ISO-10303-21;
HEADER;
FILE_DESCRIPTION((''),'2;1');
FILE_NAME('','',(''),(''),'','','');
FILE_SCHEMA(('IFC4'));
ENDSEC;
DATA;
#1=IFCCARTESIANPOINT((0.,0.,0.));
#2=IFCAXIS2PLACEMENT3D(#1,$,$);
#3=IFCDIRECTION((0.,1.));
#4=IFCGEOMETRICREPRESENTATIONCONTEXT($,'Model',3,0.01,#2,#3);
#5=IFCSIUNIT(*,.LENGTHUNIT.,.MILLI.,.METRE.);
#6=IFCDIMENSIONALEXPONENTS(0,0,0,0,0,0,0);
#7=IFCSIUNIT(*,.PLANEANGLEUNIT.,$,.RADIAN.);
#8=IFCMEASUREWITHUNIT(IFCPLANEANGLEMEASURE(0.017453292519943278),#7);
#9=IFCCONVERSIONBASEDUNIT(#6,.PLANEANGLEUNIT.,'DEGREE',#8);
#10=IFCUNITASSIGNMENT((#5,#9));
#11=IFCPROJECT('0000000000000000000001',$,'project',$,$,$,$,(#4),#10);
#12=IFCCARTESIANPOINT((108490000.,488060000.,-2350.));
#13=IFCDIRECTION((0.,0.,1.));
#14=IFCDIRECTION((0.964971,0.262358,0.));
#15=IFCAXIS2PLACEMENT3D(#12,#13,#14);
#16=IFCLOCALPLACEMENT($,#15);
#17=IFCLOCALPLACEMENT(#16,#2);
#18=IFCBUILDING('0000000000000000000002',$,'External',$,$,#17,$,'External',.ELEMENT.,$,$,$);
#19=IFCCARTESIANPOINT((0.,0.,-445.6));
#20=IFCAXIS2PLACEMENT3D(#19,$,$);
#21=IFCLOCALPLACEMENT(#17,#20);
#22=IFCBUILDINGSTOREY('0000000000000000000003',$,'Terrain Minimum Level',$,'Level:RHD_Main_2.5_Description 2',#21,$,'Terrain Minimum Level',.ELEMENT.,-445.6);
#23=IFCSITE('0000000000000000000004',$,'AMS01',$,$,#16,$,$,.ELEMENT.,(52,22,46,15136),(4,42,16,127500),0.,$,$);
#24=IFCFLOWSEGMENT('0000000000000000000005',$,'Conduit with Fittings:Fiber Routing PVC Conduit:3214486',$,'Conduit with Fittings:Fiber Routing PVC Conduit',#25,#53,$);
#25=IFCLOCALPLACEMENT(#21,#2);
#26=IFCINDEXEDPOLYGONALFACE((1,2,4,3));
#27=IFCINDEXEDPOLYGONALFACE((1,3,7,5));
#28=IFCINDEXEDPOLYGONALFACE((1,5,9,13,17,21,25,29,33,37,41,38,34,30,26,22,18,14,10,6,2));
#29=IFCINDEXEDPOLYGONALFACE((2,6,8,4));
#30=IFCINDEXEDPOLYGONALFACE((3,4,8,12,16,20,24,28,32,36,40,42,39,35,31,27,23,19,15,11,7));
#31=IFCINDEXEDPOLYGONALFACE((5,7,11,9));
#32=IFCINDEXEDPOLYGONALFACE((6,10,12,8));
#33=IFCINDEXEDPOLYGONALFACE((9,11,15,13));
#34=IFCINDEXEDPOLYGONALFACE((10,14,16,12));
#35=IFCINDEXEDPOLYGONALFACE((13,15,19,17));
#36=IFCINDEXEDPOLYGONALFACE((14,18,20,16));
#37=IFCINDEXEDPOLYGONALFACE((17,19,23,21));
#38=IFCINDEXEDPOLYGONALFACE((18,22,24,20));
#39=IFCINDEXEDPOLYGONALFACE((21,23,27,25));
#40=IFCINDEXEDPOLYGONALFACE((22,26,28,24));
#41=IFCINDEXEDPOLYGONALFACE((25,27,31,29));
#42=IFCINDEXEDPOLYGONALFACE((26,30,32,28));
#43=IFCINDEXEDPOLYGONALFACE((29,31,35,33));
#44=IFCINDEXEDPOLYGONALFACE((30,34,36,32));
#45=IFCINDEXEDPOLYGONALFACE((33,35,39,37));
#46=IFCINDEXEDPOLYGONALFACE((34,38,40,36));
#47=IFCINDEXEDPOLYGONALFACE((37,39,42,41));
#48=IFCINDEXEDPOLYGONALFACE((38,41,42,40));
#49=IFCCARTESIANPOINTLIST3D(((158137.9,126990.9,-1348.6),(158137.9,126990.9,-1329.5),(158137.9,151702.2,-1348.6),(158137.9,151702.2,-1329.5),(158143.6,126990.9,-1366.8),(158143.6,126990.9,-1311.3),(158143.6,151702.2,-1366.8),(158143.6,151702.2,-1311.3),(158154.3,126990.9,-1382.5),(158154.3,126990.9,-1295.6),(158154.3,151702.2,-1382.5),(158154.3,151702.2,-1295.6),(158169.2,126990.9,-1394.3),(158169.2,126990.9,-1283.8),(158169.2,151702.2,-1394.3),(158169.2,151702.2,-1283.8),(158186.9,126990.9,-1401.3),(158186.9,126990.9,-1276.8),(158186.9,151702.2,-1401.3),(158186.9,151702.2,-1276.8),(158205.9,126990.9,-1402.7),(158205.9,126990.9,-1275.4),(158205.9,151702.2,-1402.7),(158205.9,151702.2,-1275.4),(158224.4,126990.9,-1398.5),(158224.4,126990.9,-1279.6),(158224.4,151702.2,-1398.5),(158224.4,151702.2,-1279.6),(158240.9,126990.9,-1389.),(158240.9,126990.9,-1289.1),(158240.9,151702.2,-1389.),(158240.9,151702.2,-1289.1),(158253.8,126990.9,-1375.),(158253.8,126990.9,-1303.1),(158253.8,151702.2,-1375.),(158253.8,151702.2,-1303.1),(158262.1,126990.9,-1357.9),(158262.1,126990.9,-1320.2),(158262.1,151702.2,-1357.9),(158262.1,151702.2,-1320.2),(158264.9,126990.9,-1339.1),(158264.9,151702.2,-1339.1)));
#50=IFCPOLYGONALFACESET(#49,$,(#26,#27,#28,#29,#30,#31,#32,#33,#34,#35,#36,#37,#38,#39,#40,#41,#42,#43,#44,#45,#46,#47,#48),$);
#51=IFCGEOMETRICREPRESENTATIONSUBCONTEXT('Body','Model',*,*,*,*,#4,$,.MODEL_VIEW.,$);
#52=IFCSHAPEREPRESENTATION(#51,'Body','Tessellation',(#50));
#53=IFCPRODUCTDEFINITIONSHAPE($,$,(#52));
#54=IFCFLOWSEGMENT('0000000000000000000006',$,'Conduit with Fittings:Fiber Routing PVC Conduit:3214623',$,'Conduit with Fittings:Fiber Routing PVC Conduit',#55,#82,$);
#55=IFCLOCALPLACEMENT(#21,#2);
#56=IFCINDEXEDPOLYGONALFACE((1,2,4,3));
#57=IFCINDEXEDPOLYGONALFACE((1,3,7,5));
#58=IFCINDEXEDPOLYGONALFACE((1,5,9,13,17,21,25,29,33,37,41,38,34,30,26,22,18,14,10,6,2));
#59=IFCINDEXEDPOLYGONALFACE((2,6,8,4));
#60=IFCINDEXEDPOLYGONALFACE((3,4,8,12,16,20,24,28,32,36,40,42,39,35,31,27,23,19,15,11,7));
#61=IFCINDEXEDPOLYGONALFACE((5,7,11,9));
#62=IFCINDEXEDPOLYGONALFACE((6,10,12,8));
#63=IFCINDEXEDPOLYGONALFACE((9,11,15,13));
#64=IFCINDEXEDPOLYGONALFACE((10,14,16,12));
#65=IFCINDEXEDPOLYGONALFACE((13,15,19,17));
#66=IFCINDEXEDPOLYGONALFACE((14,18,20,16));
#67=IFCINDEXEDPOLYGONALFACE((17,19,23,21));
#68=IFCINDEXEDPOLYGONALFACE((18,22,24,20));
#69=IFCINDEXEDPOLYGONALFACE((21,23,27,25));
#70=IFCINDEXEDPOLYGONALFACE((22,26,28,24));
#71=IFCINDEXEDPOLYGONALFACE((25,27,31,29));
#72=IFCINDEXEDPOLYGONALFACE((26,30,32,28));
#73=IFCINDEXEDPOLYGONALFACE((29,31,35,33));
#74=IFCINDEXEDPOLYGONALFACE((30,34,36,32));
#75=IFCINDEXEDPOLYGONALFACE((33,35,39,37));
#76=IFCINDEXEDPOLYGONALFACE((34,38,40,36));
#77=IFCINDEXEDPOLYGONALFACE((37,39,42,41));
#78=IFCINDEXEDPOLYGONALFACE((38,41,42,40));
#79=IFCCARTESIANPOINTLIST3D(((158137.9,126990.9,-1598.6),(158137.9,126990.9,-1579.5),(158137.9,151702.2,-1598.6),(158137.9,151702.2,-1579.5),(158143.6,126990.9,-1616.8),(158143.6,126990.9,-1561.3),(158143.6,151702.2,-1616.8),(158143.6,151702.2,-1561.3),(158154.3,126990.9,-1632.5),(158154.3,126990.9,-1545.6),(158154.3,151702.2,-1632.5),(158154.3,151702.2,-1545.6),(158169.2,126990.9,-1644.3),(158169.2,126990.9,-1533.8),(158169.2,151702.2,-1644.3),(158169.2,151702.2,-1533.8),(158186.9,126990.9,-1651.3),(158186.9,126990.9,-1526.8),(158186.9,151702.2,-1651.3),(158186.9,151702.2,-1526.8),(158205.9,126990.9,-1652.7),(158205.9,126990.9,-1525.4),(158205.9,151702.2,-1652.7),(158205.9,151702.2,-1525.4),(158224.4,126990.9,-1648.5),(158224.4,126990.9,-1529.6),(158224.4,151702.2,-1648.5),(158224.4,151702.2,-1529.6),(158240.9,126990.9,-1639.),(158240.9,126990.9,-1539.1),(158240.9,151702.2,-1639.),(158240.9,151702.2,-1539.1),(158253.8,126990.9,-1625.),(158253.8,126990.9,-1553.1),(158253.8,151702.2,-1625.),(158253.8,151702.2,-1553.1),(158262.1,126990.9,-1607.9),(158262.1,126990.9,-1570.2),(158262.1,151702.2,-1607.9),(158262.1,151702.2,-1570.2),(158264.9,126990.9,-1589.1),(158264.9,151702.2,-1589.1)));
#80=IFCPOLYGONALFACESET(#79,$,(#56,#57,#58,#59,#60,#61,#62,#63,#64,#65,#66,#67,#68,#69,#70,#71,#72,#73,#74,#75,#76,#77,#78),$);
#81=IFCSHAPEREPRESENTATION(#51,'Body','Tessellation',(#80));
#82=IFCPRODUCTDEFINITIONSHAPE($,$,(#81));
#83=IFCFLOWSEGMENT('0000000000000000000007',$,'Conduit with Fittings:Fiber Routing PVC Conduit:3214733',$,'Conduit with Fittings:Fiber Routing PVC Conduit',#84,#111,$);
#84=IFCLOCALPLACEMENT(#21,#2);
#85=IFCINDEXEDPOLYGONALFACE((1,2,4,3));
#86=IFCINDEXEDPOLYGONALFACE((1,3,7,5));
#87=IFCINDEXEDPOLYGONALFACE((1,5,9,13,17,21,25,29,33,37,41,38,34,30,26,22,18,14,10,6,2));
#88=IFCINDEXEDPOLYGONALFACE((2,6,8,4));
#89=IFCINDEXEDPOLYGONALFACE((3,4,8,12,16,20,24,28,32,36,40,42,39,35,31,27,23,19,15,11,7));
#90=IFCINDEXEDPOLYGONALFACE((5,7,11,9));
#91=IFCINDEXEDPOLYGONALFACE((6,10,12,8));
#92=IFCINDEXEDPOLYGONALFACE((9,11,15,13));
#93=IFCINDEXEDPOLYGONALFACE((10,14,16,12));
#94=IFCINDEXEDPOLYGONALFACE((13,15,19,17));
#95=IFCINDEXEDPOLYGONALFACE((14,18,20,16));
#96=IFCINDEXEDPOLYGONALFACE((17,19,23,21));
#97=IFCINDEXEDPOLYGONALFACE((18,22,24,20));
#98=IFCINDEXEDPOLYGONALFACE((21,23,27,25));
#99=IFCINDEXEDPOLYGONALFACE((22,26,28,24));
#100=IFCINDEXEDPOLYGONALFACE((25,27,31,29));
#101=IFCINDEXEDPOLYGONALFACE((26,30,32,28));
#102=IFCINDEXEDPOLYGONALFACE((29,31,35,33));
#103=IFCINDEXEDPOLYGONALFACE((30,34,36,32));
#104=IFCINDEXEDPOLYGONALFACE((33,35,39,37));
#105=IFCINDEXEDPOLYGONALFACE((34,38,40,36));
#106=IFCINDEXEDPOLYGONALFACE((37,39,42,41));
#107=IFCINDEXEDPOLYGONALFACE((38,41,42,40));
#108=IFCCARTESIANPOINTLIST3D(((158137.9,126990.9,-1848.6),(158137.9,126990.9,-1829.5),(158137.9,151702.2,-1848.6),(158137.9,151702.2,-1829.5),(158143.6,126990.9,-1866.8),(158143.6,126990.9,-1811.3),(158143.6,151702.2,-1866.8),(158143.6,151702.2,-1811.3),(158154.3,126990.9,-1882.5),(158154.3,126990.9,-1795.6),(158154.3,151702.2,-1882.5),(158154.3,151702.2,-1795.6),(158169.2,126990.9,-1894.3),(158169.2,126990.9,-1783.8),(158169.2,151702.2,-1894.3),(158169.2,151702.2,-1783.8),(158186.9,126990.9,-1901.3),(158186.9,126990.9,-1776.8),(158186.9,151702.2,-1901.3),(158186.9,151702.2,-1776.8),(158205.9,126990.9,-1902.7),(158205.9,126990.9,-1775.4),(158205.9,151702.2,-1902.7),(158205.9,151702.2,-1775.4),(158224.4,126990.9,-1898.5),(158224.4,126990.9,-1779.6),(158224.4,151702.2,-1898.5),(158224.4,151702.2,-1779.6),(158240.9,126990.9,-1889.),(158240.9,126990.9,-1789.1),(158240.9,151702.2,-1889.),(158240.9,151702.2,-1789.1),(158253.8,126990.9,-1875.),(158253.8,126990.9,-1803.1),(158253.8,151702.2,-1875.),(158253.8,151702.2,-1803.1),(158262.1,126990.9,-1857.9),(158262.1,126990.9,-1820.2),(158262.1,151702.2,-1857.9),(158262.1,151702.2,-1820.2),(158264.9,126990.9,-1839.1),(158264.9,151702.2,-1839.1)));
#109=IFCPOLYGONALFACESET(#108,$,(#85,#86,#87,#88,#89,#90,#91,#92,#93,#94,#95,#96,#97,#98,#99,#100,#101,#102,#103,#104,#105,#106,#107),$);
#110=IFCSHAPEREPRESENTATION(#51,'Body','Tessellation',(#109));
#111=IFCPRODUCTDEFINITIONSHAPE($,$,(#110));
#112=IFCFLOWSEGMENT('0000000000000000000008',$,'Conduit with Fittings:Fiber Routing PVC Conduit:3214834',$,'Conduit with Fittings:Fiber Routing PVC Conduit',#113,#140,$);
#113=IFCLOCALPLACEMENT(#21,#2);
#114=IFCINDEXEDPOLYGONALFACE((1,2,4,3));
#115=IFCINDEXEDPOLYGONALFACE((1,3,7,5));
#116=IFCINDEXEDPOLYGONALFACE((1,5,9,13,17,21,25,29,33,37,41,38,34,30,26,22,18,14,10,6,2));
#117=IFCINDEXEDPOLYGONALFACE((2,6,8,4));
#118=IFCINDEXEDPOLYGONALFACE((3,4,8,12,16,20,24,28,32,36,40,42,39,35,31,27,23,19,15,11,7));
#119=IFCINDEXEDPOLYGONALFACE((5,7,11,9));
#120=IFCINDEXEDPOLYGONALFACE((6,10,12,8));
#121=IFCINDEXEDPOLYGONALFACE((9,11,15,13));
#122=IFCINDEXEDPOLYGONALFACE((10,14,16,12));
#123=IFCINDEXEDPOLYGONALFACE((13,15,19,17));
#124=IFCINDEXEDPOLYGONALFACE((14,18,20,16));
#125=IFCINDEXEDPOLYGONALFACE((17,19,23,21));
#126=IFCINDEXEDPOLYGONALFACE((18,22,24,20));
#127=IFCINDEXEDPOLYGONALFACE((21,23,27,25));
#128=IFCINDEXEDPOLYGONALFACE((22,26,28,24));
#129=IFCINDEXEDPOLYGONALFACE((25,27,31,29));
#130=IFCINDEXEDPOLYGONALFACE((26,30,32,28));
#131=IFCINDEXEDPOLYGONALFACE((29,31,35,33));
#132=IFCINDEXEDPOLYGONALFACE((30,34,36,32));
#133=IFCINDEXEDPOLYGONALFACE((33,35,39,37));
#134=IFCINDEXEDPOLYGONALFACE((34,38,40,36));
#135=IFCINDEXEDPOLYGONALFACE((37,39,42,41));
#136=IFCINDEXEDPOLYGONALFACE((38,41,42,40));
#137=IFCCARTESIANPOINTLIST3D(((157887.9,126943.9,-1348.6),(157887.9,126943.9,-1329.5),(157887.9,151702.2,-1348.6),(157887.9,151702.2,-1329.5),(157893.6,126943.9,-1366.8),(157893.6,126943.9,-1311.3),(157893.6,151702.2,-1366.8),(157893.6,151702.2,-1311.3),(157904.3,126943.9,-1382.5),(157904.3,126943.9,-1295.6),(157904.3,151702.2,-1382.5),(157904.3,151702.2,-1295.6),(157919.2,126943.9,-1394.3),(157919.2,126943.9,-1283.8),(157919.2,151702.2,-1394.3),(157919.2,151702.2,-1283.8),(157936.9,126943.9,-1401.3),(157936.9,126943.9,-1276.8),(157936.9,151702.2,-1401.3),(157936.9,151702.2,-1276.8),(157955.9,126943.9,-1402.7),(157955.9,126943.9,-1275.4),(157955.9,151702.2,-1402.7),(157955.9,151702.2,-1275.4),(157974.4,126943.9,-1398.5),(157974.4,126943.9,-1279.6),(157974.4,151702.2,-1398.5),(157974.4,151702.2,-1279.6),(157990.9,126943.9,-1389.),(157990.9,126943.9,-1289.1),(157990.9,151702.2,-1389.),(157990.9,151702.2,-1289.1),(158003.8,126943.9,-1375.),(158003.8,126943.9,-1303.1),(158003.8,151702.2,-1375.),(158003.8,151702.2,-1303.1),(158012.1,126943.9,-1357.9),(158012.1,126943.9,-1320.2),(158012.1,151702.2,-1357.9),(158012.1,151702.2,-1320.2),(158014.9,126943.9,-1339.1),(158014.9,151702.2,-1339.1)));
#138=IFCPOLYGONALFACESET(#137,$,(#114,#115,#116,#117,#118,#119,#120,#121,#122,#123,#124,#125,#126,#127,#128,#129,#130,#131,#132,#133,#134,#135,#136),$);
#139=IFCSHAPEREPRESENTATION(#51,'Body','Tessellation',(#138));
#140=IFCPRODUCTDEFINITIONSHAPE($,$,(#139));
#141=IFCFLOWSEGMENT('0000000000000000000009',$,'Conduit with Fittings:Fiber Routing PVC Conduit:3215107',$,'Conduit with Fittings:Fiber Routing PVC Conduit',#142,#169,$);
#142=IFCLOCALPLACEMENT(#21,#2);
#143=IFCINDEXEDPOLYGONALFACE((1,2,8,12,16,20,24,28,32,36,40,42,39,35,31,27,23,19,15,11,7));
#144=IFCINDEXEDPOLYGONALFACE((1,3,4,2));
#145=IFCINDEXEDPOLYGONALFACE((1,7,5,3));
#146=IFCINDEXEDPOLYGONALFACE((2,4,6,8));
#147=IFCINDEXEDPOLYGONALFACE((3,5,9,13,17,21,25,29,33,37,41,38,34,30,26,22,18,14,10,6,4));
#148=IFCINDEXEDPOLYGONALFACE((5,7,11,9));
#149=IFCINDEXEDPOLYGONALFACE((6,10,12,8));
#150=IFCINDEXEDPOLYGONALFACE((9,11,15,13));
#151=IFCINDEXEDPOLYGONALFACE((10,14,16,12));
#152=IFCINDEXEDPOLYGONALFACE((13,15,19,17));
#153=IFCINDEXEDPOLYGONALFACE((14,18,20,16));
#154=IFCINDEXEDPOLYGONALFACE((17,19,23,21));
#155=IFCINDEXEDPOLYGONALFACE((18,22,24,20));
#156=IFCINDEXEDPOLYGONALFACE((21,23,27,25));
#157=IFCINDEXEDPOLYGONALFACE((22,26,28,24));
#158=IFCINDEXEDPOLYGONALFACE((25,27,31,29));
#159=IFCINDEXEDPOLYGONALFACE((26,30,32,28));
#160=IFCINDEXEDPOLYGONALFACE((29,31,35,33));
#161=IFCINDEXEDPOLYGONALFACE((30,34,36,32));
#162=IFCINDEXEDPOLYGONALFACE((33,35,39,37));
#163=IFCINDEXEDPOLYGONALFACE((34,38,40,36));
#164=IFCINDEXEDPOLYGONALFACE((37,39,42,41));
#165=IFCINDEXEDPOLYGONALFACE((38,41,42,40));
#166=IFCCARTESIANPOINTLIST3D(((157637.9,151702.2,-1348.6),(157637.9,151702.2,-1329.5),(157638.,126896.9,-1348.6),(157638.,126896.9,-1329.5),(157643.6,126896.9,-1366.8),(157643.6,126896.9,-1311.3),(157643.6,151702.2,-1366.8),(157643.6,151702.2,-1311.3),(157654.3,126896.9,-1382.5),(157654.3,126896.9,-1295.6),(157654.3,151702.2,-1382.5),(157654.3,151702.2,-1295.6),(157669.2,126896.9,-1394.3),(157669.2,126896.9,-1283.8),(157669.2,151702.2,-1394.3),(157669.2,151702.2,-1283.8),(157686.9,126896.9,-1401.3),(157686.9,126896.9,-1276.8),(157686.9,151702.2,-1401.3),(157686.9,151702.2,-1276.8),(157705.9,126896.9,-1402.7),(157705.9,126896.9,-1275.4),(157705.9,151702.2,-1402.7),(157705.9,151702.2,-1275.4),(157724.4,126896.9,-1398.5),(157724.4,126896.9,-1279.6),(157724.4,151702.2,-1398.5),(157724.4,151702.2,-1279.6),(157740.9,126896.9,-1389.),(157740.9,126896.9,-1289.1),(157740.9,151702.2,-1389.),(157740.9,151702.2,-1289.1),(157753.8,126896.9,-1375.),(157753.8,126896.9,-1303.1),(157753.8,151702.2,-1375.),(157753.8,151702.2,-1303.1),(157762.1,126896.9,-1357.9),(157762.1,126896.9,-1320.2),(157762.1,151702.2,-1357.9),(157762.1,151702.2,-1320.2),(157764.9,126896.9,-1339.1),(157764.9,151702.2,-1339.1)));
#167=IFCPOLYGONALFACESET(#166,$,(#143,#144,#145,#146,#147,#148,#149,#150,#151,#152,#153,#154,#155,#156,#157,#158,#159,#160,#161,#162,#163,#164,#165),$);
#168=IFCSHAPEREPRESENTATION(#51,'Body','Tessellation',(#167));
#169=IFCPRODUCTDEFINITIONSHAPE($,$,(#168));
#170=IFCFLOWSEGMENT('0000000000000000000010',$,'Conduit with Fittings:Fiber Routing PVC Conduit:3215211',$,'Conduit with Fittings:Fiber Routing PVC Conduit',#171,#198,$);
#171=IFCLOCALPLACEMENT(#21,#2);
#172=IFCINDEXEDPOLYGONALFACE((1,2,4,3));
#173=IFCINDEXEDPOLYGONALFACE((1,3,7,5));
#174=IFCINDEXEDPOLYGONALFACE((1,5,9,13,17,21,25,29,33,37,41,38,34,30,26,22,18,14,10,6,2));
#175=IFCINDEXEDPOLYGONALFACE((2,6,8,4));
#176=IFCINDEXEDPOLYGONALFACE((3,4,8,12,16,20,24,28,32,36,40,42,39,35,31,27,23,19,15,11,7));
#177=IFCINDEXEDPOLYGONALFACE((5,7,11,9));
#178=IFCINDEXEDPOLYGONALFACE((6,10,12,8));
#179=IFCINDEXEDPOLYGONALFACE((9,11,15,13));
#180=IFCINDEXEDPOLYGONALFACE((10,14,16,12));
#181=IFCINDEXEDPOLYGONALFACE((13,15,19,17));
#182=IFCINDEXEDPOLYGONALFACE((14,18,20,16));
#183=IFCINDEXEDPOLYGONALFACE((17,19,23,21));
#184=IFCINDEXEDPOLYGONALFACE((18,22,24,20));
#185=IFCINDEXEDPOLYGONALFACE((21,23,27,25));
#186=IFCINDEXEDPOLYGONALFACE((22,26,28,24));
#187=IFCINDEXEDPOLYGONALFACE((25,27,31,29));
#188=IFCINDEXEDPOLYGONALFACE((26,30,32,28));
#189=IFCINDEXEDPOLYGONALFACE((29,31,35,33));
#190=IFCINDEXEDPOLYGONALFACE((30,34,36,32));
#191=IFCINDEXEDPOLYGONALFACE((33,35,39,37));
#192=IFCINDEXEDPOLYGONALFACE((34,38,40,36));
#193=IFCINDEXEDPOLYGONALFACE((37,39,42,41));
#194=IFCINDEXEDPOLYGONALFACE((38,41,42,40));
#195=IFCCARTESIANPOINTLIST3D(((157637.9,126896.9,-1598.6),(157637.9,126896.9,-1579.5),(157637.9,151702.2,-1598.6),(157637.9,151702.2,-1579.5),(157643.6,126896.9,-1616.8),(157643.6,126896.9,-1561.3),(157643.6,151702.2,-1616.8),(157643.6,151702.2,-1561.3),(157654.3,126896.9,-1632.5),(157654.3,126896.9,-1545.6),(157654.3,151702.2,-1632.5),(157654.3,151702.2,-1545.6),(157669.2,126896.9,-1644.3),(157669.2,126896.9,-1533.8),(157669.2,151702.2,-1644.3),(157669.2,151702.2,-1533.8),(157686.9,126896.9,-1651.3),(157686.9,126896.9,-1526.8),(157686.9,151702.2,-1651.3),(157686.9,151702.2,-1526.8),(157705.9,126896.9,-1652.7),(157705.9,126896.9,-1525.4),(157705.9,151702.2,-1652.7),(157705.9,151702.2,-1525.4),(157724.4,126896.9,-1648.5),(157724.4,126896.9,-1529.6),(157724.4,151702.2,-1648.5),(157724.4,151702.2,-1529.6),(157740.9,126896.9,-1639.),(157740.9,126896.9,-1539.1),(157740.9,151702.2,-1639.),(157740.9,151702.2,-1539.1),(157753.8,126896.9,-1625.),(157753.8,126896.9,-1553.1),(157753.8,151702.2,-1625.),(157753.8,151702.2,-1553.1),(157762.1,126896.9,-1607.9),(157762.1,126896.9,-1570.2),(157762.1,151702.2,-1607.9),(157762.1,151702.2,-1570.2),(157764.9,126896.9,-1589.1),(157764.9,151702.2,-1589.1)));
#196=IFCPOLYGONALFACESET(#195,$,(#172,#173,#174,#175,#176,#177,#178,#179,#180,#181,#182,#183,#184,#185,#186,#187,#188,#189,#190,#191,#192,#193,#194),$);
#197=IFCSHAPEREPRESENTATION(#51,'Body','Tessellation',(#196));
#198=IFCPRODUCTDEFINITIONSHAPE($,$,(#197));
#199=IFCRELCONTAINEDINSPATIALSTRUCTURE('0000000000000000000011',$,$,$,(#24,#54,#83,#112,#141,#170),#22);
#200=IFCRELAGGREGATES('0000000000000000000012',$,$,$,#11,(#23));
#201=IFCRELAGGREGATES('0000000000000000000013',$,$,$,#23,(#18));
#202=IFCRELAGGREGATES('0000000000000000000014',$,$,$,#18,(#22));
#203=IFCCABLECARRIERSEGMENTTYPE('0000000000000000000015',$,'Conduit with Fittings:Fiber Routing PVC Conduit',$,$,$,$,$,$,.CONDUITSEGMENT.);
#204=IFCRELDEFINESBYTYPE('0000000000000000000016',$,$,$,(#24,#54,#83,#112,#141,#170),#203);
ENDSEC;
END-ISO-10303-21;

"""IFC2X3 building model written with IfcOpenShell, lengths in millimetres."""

from ifc_helpers import new_model, entity, si_unit, converted_unit, direction, frame, origin, origin_2d_with_axis, place, context, subcontext, project, spatial, circle, extrude, type_object, element, save


model = new_model("IFC2X3")

# Units and contexts
model_context = context("Model", 3, precision=0.01, world=origin(), true_north=direction((0.0, 1.0)))
body_context = subcontext(model_context, "Body", "Model", "MODEL_VIEW")
ifc_project = project(units=[si_unit("LENGTHUNIT", "METRE", prefix="MILLI"), converted_unit("PLANEANGLEUNIT", "DEGREE", entity("IfcPlaneAngleMeasure", 0.017453292519943278), si_unit("PLANEANGLEUNIT", "RADIAN"), dimensions=[0, 0, 0, 0, 0, 0, 0])], contexts=[model_context])

# Site, building, storey
site_placement = place(None, frame((108490000.0, 488060000.0, -2350.0), z_axis=(0.0, 0.0, 1.0), x_axis=(0.964971, 0.262358, 0.0)))
site = spatial("IfcSite", under=ifc_project, at=site_placement, Name="AMS01", CompositionType="ELEMENT", RefLatitude=(52, 22, 46, 15136), RefLongitude=(4, 42, 16, 127500), RefElevation=0.0)
building_placement = place(site_placement, origin())
building = spatial("IfcBuilding", under=site, at=building_placement, Name="External", LongName="External", CompositionType="ELEMENT")
storey_placement = place(building_placement, frame((0.0, 0.0, -445.6)))
storey = spatial("IfcBuildingStorey", under=building, at=storey_placement, Name="Terrain Minimum Level", ObjectType="Level:RHD_Main_2.5_Description 2", LongName="Terrain Minimum Level", CompositionType="ELEMENT", Elevation=-445.6)

# Flow segments
cable_carrier_segment_type = type_object("IfcCableCarrierSegmentType", Name="Conduit with Fittings:Fiber Routing PVC Conduit", PredefinedType="CONDUITSEGMENT")
flow_segment_1_placement = place(storey_placement, origin())
element("IfcFlowSegment", 1, at=flow_segment_1_placement, inside=storey, type_object=cable_carrier_segment_type, Name="Conduit with Fittings:Fiber Routing PVC Conduit:3214486", ObjectType="Conduit with Fittings:Fiber Routing PVC Conduit", context=body_context, shape_type="SweptSolid", body=[
    extrude(circle(Radius=63.9, at=origin_2d_with_axis()), frame((158201.1, 126990.9, -1339.1), z_axis=(0.0, 1.0, 0.0), x_axis=(1.0, 0.0, 0.0)), (0.0, 0.0, 1.0), 24711.3),
])
flow_segment_2_placement = place(storey_placement, origin())
element("IfcFlowSegment", 2, at=flow_segment_2_placement, inside=storey, type_object=cable_carrier_segment_type, Name="Conduit with Fittings:Fiber Routing PVC Conduit:3214623", ObjectType="Conduit with Fittings:Fiber Routing PVC Conduit", context=body_context, shape_type="SweptSolid", body=[
    extrude(circle(Radius=63.9, at=origin_2d_with_axis()), frame((158201.1, 126990.9, -1589.1), z_axis=(0.0, 1.0, 0.0), x_axis=(1.0, 0.0, 0.0)), (0.0, 0.0, 1.0), 24711.3),
])
flow_segment_3_placement = place(storey_placement, origin())
element("IfcFlowSegment", 3, at=flow_segment_3_placement, inside=storey, type_object=cable_carrier_segment_type, Name="Conduit with Fittings:Fiber Routing PVC Conduit:3214733", ObjectType="Conduit with Fittings:Fiber Routing PVC Conduit", context=body_context, shape_type="SweptSolid", body=[
    extrude(circle(Radius=63.9, at=origin_2d_with_axis()), frame((158201.1, 126990.9, -1839.1), z_axis=(0.0, 1.0, 0.0), x_axis=(1.0, 0.0, 0.0)), (0.0, 0.0, 1.0), 24711.3),
])
flow_segment_4_placement = place(storey_placement, origin())
element("IfcFlowSegment", 4, at=flow_segment_4_placement, inside=storey, type_object=cable_carrier_segment_type, Name="Conduit with Fittings:Fiber Routing PVC Conduit:3214834", ObjectType="Conduit with Fittings:Fiber Routing PVC Conduit", context=body_context, shape_type="SweptSolid", body=[
    extrude(circle(Radius=63.9, at=origin_2d_with_axis()), frame((157951.1, 126943.9, -1339.1), z_axis=(0.0, 1.0, 0.0), x_axis=(1.0, 0.0, 0.0)), (0.0, 0.0, 1.0), 24758.3),
])
flow_segment_5_placement = place(storey_placement, origin())
element("IfcFlowSegment", 5, at=flow_segment_5_placement, inside=storey, type_object=cable_carrier_segment_type, Name="Conduit with Fittings:Fiber Routing PVC Conduit:3215107", ObjectType="Conduit with Fittings:Fiber Routing PVC Conduit", context=body_context, shape_type="SweptSolid", body=[
    extrude(circle(Radius=63.9, at=origin_2d_with_axis()), frame((157701.1, 126896.9, -1339.1), z_axis=(0.0, 1.0, 0.0), x_axis=(1.0, 0.0, 0.0)), (0.0, 0.0, 1.0), 24805.4),
])
flow_segment_6_placement = place(storey_placement, origin())
element("IfcFlowSegment", 6, at=flow_segment_6_placement, inside=storey, type_object=cable_carrier_segment_type, Name="Conduit with Fittings:Fiber Routing PVC Conduit:3215211", ObjectType="Conduit with Fittings:Fiber Routing PVC Conduit", context=body_context, shape_type="SweptSolid", body=[
    extrude(circle(Radius=63.9, at=origin_2d_with_axis()), frame((157701.1, 126896.9, -1589.1), z_axis=(0.0, 1.0, 0.0), x_axis=(1.0, 0.0, 0.0)), (0.0, 0.0, 1.0), 24805.3),
])

save(model, "model.ifc")
